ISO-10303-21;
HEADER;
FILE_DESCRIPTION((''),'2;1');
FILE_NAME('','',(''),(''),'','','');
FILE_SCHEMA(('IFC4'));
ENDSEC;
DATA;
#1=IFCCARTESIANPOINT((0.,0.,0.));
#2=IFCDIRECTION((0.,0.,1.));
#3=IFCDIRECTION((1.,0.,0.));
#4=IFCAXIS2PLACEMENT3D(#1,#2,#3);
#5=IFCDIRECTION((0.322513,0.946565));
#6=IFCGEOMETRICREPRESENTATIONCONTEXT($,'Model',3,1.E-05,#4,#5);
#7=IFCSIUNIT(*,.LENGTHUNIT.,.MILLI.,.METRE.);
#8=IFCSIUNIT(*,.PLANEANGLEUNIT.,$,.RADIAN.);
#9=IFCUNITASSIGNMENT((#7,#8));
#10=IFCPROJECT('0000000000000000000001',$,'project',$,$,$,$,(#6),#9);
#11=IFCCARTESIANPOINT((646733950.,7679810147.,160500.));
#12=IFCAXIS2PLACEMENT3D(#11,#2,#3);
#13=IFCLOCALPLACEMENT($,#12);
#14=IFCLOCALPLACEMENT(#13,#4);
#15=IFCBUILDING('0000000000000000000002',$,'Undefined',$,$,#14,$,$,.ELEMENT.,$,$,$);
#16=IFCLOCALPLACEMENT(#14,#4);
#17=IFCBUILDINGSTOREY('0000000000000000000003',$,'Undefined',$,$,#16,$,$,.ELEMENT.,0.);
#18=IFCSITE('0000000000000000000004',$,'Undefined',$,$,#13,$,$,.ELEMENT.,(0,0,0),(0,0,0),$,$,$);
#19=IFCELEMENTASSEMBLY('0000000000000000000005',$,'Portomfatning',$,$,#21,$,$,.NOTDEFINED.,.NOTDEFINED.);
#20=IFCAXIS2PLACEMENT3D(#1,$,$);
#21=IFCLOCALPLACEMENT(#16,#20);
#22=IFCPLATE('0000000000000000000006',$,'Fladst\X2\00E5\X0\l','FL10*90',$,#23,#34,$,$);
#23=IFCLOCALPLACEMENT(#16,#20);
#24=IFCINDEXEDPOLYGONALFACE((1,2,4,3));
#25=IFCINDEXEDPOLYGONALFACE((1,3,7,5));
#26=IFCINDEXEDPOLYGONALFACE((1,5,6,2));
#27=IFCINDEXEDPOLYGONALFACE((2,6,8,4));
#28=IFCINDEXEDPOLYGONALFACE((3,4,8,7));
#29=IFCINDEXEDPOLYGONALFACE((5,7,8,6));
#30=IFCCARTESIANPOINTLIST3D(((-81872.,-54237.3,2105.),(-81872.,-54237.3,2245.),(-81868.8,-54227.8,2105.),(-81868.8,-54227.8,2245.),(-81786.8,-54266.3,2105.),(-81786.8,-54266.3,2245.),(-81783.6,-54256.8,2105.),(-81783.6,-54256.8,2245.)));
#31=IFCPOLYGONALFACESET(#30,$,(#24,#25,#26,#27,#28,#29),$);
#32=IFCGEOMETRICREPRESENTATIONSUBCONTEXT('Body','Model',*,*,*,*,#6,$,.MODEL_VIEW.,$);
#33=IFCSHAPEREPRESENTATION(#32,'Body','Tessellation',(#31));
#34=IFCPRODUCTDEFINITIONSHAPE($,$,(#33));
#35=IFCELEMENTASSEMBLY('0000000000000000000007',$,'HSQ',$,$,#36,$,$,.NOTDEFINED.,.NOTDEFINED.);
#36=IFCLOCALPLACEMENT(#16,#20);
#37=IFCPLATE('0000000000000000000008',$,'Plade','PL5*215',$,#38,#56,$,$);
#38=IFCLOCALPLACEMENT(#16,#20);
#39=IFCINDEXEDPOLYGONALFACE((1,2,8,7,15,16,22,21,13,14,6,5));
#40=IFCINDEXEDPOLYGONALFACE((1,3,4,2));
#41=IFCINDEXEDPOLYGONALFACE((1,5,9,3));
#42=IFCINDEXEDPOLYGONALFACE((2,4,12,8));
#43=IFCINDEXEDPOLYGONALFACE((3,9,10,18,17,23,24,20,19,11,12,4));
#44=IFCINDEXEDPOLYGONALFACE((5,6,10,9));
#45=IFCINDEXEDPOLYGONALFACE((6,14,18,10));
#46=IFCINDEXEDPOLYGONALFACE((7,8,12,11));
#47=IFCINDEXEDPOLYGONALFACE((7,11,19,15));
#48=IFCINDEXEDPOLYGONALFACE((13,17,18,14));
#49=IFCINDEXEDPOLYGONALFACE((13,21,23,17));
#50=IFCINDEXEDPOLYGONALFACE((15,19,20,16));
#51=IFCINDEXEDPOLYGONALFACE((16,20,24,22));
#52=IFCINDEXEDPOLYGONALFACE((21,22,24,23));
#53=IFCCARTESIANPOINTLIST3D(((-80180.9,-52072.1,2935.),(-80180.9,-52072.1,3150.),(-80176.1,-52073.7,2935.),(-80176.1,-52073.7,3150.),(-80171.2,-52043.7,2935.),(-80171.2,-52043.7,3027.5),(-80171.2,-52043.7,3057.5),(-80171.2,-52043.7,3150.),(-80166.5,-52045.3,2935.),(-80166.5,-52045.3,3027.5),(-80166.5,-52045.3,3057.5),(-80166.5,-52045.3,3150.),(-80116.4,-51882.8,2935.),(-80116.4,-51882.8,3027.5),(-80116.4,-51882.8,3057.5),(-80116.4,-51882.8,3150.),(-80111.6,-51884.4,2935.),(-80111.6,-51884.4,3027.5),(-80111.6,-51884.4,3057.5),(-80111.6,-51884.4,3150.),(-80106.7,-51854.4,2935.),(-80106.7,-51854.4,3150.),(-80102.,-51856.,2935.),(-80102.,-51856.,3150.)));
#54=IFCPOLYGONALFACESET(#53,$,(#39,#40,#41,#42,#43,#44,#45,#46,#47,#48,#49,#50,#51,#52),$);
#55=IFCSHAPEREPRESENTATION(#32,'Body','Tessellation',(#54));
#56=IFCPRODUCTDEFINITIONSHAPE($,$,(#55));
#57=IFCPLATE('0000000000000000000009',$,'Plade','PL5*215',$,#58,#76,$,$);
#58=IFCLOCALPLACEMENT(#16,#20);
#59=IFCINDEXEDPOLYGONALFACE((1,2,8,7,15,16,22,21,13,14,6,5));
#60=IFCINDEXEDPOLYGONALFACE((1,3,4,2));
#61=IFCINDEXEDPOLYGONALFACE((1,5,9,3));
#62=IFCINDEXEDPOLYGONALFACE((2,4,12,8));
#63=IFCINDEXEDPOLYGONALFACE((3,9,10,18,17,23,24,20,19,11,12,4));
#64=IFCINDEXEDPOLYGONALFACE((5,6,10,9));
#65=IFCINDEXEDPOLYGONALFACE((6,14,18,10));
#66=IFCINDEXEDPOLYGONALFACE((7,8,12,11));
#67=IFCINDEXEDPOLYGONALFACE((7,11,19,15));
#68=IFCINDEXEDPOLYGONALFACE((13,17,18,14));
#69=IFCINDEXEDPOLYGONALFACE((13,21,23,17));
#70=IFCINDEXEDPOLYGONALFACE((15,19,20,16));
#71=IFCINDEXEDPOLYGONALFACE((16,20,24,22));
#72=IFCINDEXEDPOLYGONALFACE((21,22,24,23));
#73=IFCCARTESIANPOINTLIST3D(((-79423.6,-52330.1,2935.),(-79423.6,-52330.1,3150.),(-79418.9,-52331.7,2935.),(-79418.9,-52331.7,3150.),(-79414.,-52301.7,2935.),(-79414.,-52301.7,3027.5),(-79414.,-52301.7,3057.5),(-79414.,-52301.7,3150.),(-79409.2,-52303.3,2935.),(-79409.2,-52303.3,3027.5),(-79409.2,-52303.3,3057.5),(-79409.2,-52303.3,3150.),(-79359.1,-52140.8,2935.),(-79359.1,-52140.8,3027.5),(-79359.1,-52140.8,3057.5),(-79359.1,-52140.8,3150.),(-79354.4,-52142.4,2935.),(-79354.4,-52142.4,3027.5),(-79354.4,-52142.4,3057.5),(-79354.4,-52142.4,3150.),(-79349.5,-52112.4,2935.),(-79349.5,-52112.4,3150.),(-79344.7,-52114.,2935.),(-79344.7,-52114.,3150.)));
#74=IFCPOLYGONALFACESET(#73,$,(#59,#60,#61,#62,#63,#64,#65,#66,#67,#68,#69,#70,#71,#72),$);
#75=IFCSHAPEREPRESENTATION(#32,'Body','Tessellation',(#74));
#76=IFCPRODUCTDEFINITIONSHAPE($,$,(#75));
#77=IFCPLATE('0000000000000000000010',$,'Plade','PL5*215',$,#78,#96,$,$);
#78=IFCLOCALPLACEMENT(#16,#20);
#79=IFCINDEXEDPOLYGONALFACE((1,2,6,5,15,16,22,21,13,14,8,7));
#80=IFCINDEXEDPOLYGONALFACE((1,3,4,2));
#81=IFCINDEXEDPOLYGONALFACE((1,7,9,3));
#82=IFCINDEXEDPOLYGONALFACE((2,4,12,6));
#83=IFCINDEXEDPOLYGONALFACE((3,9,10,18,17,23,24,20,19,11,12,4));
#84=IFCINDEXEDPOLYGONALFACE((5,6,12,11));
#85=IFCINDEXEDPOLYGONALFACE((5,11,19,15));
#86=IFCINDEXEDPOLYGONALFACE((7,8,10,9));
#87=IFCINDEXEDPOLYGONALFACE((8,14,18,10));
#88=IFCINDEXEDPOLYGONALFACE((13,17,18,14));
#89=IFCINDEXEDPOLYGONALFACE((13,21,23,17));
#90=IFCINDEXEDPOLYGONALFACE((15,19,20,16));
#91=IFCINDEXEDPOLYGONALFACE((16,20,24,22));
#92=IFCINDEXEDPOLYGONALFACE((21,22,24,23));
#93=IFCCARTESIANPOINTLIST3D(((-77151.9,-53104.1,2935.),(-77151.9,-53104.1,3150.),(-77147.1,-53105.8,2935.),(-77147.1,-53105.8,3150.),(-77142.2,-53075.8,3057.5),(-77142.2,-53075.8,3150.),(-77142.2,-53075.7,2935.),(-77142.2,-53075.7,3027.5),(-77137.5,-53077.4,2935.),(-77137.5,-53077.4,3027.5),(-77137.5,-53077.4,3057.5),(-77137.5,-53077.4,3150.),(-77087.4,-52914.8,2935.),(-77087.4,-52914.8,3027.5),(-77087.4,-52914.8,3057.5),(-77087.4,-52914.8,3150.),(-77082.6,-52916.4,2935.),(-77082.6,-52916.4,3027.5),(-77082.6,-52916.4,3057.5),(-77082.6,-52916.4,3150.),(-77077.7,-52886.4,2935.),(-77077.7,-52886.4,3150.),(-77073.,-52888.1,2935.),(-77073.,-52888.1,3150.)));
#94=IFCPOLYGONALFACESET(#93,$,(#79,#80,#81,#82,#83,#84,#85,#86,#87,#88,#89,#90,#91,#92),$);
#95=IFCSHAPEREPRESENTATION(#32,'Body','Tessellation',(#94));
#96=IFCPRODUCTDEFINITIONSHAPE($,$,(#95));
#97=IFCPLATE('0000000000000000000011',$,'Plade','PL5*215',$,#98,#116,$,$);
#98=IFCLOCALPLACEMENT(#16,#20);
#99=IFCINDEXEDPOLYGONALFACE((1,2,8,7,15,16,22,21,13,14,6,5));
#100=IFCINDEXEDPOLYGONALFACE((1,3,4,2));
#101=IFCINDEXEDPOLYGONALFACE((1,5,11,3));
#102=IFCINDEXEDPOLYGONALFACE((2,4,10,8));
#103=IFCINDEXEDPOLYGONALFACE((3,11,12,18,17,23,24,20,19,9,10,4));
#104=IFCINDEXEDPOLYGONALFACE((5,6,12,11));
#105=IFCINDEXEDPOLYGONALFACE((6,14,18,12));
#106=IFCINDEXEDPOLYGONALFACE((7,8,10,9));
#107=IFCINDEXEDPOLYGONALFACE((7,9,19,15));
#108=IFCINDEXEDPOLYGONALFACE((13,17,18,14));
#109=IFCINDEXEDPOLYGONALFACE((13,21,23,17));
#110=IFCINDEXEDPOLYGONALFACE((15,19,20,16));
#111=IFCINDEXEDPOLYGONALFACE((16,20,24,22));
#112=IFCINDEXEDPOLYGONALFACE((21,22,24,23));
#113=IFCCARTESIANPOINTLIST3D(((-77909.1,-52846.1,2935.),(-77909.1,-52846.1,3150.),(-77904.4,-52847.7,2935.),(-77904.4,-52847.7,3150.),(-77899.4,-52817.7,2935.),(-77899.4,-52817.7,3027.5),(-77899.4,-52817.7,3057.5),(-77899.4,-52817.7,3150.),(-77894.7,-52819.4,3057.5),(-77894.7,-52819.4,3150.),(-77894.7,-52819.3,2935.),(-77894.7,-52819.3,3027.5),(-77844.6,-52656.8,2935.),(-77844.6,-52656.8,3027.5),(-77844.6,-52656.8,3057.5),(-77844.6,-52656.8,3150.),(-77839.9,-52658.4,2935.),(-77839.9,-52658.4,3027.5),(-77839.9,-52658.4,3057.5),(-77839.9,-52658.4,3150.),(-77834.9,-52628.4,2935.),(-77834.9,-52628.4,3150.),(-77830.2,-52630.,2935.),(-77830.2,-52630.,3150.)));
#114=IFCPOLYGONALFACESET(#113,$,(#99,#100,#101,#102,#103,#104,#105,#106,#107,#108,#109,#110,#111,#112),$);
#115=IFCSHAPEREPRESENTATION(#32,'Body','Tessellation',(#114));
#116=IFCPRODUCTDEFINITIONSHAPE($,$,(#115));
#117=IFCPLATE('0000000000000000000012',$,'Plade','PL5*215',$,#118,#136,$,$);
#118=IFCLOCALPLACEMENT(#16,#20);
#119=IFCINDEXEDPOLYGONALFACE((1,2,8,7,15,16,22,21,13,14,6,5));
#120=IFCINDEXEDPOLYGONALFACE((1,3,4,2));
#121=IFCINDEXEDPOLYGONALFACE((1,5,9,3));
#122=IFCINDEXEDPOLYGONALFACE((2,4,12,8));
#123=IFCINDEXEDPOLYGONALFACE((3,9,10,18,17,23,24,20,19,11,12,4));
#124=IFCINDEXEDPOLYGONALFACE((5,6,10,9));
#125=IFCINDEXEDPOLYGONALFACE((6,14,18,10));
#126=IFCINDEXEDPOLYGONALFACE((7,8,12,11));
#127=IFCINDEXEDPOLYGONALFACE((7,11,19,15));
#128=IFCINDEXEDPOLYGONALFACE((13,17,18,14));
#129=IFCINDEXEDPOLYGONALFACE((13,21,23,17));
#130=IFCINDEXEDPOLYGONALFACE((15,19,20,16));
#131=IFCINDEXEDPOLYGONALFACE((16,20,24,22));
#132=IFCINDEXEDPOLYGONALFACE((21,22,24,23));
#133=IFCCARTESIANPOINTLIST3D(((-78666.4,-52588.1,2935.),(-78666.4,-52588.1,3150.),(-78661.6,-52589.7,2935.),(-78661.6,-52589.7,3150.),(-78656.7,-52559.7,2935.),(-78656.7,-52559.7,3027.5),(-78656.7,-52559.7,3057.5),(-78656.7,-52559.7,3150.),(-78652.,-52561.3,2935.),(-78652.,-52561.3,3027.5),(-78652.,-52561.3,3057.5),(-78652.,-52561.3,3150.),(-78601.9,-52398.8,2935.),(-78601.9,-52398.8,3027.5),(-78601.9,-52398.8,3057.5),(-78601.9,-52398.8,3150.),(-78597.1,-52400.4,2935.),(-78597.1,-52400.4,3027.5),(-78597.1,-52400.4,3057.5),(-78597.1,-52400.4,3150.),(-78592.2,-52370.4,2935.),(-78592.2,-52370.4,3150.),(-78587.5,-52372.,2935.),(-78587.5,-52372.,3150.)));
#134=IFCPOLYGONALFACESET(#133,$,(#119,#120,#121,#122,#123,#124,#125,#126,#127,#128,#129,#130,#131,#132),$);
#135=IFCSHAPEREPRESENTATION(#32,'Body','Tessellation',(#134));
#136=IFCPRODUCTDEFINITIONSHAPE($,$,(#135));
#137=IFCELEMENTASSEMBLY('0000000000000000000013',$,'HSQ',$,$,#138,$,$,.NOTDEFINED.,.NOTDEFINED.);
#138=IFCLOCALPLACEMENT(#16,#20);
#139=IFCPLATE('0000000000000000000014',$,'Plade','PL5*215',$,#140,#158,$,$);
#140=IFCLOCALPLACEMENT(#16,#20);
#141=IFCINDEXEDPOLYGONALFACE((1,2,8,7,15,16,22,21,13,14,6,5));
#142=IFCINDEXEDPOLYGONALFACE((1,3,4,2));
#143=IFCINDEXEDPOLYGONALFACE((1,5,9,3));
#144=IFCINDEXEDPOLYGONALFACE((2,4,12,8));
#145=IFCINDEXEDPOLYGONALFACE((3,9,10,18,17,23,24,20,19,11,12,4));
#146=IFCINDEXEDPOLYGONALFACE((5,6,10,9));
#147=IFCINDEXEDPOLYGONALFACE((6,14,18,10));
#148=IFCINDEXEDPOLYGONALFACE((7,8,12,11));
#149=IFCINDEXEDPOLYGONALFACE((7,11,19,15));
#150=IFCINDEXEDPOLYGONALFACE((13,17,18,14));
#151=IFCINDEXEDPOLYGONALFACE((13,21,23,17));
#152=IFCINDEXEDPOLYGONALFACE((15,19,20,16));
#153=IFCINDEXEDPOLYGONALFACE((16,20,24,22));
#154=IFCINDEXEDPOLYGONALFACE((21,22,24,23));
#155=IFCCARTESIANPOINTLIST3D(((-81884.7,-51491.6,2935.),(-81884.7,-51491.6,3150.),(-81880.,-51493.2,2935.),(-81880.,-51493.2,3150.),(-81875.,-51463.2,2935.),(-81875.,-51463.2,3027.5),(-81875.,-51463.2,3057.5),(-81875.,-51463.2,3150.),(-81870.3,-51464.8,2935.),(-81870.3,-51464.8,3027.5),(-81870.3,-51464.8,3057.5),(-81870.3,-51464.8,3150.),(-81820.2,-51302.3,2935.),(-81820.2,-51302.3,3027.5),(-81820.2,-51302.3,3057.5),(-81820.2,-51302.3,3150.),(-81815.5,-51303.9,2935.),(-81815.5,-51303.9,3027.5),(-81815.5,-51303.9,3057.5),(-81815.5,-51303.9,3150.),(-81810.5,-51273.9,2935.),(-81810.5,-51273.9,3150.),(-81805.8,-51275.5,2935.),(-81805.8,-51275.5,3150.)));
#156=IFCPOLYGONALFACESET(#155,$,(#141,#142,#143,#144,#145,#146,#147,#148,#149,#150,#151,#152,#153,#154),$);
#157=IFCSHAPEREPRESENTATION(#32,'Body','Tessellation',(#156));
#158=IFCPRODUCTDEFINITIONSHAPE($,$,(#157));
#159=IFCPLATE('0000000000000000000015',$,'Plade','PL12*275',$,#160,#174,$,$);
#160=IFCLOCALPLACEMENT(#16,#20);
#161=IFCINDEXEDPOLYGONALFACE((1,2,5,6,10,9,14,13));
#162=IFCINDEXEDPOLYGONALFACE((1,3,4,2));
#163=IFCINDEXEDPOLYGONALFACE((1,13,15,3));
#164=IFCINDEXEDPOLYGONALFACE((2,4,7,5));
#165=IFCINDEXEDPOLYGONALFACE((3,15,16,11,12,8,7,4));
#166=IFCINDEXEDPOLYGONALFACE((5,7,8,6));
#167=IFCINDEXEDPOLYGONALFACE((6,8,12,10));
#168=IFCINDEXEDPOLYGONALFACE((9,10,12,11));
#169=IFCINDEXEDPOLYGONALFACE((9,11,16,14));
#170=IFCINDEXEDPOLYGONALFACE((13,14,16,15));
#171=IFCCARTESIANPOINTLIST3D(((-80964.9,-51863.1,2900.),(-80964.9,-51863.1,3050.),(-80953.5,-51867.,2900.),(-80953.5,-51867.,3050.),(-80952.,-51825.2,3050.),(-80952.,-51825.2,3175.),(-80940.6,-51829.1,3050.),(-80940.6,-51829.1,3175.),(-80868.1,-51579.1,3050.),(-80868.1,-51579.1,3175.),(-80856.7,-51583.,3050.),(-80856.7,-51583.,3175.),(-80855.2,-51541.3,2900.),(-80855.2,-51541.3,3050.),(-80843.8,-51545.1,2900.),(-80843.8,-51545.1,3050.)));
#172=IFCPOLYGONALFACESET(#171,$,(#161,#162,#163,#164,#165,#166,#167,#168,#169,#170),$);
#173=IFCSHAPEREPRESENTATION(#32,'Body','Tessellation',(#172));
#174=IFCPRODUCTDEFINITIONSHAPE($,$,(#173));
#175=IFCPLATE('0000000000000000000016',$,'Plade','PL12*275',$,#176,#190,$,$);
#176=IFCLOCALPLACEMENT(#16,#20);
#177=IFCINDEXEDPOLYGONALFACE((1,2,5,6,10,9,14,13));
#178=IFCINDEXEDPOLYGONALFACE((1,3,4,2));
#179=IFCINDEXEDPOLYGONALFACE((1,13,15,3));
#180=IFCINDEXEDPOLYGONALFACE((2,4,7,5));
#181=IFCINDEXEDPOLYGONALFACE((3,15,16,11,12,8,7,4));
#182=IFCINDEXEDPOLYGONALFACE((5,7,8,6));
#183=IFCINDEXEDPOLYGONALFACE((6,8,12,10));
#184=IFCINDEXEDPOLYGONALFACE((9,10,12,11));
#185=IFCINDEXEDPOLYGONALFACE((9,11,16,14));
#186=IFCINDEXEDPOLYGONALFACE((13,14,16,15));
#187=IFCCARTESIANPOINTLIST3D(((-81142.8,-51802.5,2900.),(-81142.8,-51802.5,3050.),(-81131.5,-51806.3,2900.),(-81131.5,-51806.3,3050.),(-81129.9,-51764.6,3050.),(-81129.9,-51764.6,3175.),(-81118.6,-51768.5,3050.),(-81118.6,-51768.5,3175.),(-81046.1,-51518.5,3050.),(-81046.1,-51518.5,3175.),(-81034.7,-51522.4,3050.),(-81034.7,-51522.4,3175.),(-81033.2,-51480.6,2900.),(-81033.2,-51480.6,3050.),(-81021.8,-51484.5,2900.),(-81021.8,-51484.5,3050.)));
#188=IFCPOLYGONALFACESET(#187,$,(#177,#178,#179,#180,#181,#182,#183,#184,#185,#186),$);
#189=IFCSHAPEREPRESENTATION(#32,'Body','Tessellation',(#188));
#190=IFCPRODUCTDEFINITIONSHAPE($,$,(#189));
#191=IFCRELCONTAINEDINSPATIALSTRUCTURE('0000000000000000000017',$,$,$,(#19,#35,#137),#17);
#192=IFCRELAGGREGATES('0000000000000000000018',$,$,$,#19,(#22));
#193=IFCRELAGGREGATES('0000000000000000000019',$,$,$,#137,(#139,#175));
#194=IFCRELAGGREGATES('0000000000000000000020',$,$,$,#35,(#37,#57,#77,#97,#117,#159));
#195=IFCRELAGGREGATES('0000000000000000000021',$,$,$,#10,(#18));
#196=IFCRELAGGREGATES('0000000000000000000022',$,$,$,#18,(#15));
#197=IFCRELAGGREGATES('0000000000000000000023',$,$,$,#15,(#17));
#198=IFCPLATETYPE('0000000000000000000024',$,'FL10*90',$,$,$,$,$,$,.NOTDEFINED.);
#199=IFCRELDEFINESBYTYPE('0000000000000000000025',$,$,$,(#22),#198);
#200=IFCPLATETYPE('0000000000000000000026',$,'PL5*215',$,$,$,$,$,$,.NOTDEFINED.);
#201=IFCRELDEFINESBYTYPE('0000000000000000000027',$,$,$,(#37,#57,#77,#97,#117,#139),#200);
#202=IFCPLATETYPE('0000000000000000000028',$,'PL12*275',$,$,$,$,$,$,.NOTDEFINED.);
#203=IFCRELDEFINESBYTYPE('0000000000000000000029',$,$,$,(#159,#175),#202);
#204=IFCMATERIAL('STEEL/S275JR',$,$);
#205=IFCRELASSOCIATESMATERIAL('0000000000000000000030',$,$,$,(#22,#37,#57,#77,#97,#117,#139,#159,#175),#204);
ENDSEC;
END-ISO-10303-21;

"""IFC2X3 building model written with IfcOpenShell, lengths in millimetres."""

from ifc_helpers import new_model, si_unit, direction, frame, origin_with_axes, place, context, subcontext, project, spatial, polyline, outline, extrude, material, type_object, element, aggregate, save


model = new_model("IFC2X3")

# Units and contexts
model_context = context("Model", 3, precision=1e-05, world=origin_with_axes(), true_north=direction((0.322513, 0.946565)))
body_context = subcontext(model_context, "Body", "Model", "MODEL_VIEW")
ifc_project = project(units=[si_unit("LENGTHUNIT", "METRE", prefix="MILLI"), si_unit("PLANEANGLEUNIT", "RADIAN")], contexts=[model_context])

# Site, building, storey
site_placement = place(None, frame((646733950.0, 7679810147.0, 160500.0), z_axis=(0.0, 0.0, 1.0), x_axis=(1.0, 0.0, 0.0)))
site = spatial("IfcSite", under=ifc_project, at=site_placement, Name="Undefined", CompositionType="ELEMENT", RefLatitude=(0, 0, 0), RefLongitude=(0, 0, 0))
building_placement = place(site_placement, origin_with_axes())
building = spatial("IfcBuilding", under=site, at=building_placement, Name="Undefined", CompositionType="ELEMENT")
storey_placement = place(building_placement, origin_with_axes())
storey = spatial("IfcBuildingStorey", under=building, at=storey_placement, Name="Undefined", CompositionType="ELEMENT", Elevation=0.0)

# Element assembly
assembly_1_placement = place(storey_placement, origin_with_axes())
assembly_1 = element("IfcElementAssembly", 1, at=assembly_1_placement, inside=storey, Name="Portomfatning", AssemblyPlace="NOTDEFINED", PredefinedType="NOTDEFINED")

# Shared definitions
ifc_material_1 = material(Name="STEEL/S275JR")

# Plate
plate_type_1 = type_object("IfcPlateType", Name="FL10*90", PredefinedType="NOTDEFINED")
plate_1_placement = place(assembly_1_placement, frame((-81827.8, -54247.0, 2105.0), z_axis=(-0.322513, -0.946565, 0.0), x_axis=(0.0, 0.0, 1.0)))
plate_1 = element("IfcPlate", 2, at=plate_1_placement, type_object=plate_type_1, material=ifc_material_1, Name="Fladstål", Description="FL10*90", context=body_context, shape_type="SweptSolid", body=[
    extrude(outline(polyline([(0.0, -45.0), (0.0, 45.0), (140.0, 45.0), (140.0, -45.0), (0.0, -45.0)])), frame((0.0, 0.0, -5.0), z_axis=(0.0, 0.0, 1.0), x_axis=(1.0, 0.0, 0.0)), (0.0, 0.0, 1.0), 10.0),
])

# Element assembly, plates
assembly_2_placement = place(storey_placement, origin_with_axes())
assembly_2 = element("IfcElementAssembly", 3, at=assembly_2_placement, inside=storey, Name="HSQ", AssemblyPlace="NOTDEFINED", PredefinedType="NOTDEFINED")
plate_type_2 = type_object("IfcPlateType", Name="PL5*215", PredefinedType="NOTDEFINED")
plate_2_placement = place(assembly_2_placement, frame((-80178.5, -52072.9, 3150.0), z_axis=(0.946565, -0.322513, 0.0), x_axis=(0.0, 0.0, -1.0)))
plate_2 = element("IfcPlate", 4, at=plate_2_placement, type_object=plate_type_2, material=ifc_material_1, Name="Plade", Description="PL5*215", context=body_context, shape_type="SweptSolid", body=[
    extrude(outline(polyline([(0.0, 0.0), (215.0, 0.0), (215.0, 30.0), (122.5, 30.0), (122.5, 200.0), (215.0, 200.0), (215.0, 230.0), (0.0, 230.0), (0.0, 200.0), (92.5, 200.0), (92.5, 30.0), (0.0, 30.0), (0.0, 0.0)])), frame((0.0, 0.0, -2.5), z_axis=(0.0, 0.0, 1.0), x_axis=(1.0, 0.0, 0.0)), (0.0, 0.0, 1.0), 5.0),
])
plate_3_placement = place(assembly_2_placement, frame((-79421.3, -52330.9, 3150.0), z_axis=(0.946565, -0.322513, 0.0), x_axis=(0.0, 0.0, -1.0)))
plate_3 = element("IfcPlate", 5, at=plate_3_placement, type_object=plate_type_2, material=ifc_material_1, Name="Plade", Description="PL5*215", context=body_context, shape_type="SweptSolid", body=[
    extrude(outline(polyline([(0.0, 0.0), (215.0, 0.0), (215.0, 30.0), (122.5, 30.0), (122.5, 200.0), (215.0, 200.0), (215.0, 230.0), (0.0, 230.0), (0.0, 200.0), (92.5, 200.0), (92.5, 30.0), (0.0, 30.0), (0.0, 0.0)])), frame((0.0, 0.0, -2.5), z_axis=(0.0, 0.0, 1.0), x_axis=(1.0, 0.0, 0.0)), (0.0, 0.0, 1.0), 5.0),
])
plate_4_placement = place(assembly_2_placement, frame((-77149.5, -53104.9, 3150.0), z_axis=(0.946565, -0.322513, 0.0), x_axis=(0.0, 0.0, -1.0)))
plate_4 = element("IfcPlate", 6, at=plate_4_placement, type_object=plate_type_2, material=ifc_material_1, Name="Plade", Description="PL5*215", context=body_context, shape_type="SweptSolid", body=[
    extrude(outline(polyline([(0.0, 0.0), (215.0, 0.0), (215.0, 30.0), (122.5, 30.0), (122.5, 200.0), (215.0, 200.0), (215.0, 230.0), (0.0, 230.0), (0.0, 200.0), (92.5, 200.0), (92.5, 30.0), (0.0, 30.0), (0.0, 0.0)])), frame((0.0, 0.0, -2.5), z_axis=(0.0, 0.0, 1.0), x_axis=(1.0, 0.0, 0.0)), (0.0, 0.0, 1.0), 5.0),
])
plate_5_placement = place(assembly_2_placement, frame((-77906.8, -52846.9, 3150.0), z_axis=(0.946565, -0.322513, 0.0), x_axis=(0.0, 0.0, -1.0)))
plate_5 = element("IfcPlate", 7, at=plate_5_placement, type_object=plate_type_2, material=ifc_material_1, Name="Plade", Description="PL5*215", context=body_context, shape_type="SweptSolid", body=[
    extrude(outline(polyline([(0.0, 0.0), (215.0, 0.0), (215.0, 30.0), (122.5, 30.0), (122.5, 200.0), (215.0, 200.0), (215.0, 230.0), (0.0, 230.0), (0.0, 200.0), (92.5, 200.0), (92.5, 30.0), (0.0, 30.0), (0.0, 0.0)])), frame((0.0, 0.0, -2.5), z_axis=(0.0, 0.0, 1.0), x_axis=(1.0, 0.0, 0.0)), (0.0, 0.0, 1.0), 5.0),
])
plate_6_placement = place(assembly_2_placement, frame((-78664.0, -52588.9, 3150.0), z_axis=(0.946565, -0.322513, 0.0), x_axis=(0.0, 0.0, -1.0)))
plate_6 = element("IfcPlate", 8, at=plate_6_placement, type_object=plate_type_2, material=ifc_material_1, Name="Plade", Description="PL5*215", context=body_context, shape_type="SweptSolid", body=[
    extrude(outline(polyline([(0.0, 0.0), (215.0, 0.0), (215.0, 30.0), (122.5, 30.0), (122.5, 200.0), (215.0, 200.0), (215.0, 230.0), (0.0, 230.0), (0.0, 200.0), (92.5, 200.0), (92.5, 30.0), (0.0, 30.0), (0.0, 0.0)])), frame((0.0, 0.0, -2.5), z_axis=(0.0, 0.0, 1.0), x_axis=(1.0, 0.0, 0.0)), (0.0, 0.0, 1.0), 5.0),
])

# Element assembly, plate
assembly_3_placement = place(storey_placement, origin_with_axes())
assembly_3 = element("IfcElementAssembly", 9, at=assembly_3_placement, inside=storey, Name="HSQ", AssemblyPlace="NOTDEFINED", PredefinedType="NOTDEFINED")
plate_7_placement = place(assembly_3_placement, frame((-81882.3, -51492.4, 3150.0), z_axis=(0.946565, -0.322513, 0.0), x_axis=(0.0, 0.0, -1.0)))
plate_7 = element("IfcPlate", 10, at=plate_7_placement, type_object=plate_type_2, material=ifc_material_1, Name="Plade", Description="PL5*215", context=body_context, shape_type="SweptSolid", body=[
    extrude(outline(polyline([(0.0, 0.0), (215.0, 0.0), (215.0, 30.0), (122.5, 30.0), (122.5, 200.0), (215.0, 200.0), (215.0, 230.0), (0.0, 230.0), (0.0, 200.0), (92.5, 200.0), (92.5, 30.0), (0.0, 30.0), (0.0, 0.0)])), frame((0.0, 0.0, -2.5), z_axis=(0.0, 0.0, 1.0), x_axis=(1.0, 0.0, 0.0)), (0.0, 0.0, 1.0), 5.0),
])

# Plates
plate_type_3 = type_object("IfcPlateType", Name="PL12*275", PredefinedType="NOTDEFINED")
plate_8_placement = place(assembly_2_placement, frame((-80849.5, -51543.2, 3175.0), z_axis=(0.946565, -0.322513, 0.0), x_axis=(-0.322513, -0.946565, 0.0)))
plate_8 = element("IfcPlate", 11, at=plate_8_placement, type_object=plate_type_3, material=ifc_material_1, Name="Plade", Description="PL12*275", context=body_context, shape_type="SweptSolid", body=[
    extrude(outline(polyline([(0.0, 125.0), (40.0, 125.0), (40.0, 0.0), (300.0, 0.0), (300.0, 125.0), (340.0, 125.0), (340.0, 275.0), (0.0, 275.0), (0.0, 125.0)])), frame((0.0, 0.0, -6.0), z_axis=(0.0, 0.0, 1.0), x_axis=(1.0, 0.0, 0.0)), (0.0, 0.0, 1.0), 12.0),
])
plate_9_placement = place(assembly_3_placement, frame((-81027.5, -51482.6, 3175.0), z_axis=(0.946565, -0.322513, 0.0), x_axis=(-0.322513, -0.946565, 0.0)))
plate_9 = element("IfcPlate", 12, at=plate_9_placement, type_object=plate_type_3, material=ifc_material_1, Name="Plade", Description="PL12*275", context=body_context, shape_type="SweptSolid", body=[
    extrude(outline(polyline([(0.0, 125.0), (40.0, 125.0), (40.0, 0.0), (300.0, 0.0), (300.0, 125.0), (340.0, 125.0), (340.0, 275.0), (0.0, 275.0), (0.0, 125.0)])), frame((0.0, 0.0, -6.0), z_axis=(0.0, 0.0, 1.0), x_axis=(1.0, 0.0, 0.0)), (0.0, 0.0, 1.0), 12.0),
])

aggregate(assembly_1, [plate_1])
aggregate(assembly_3, [plate_7, plate_9])
aggregate(assembly_2, [plate_2, plate_3, plate_4, plate_5, plate_6, plate_8])

save(model, "model.ifc")
